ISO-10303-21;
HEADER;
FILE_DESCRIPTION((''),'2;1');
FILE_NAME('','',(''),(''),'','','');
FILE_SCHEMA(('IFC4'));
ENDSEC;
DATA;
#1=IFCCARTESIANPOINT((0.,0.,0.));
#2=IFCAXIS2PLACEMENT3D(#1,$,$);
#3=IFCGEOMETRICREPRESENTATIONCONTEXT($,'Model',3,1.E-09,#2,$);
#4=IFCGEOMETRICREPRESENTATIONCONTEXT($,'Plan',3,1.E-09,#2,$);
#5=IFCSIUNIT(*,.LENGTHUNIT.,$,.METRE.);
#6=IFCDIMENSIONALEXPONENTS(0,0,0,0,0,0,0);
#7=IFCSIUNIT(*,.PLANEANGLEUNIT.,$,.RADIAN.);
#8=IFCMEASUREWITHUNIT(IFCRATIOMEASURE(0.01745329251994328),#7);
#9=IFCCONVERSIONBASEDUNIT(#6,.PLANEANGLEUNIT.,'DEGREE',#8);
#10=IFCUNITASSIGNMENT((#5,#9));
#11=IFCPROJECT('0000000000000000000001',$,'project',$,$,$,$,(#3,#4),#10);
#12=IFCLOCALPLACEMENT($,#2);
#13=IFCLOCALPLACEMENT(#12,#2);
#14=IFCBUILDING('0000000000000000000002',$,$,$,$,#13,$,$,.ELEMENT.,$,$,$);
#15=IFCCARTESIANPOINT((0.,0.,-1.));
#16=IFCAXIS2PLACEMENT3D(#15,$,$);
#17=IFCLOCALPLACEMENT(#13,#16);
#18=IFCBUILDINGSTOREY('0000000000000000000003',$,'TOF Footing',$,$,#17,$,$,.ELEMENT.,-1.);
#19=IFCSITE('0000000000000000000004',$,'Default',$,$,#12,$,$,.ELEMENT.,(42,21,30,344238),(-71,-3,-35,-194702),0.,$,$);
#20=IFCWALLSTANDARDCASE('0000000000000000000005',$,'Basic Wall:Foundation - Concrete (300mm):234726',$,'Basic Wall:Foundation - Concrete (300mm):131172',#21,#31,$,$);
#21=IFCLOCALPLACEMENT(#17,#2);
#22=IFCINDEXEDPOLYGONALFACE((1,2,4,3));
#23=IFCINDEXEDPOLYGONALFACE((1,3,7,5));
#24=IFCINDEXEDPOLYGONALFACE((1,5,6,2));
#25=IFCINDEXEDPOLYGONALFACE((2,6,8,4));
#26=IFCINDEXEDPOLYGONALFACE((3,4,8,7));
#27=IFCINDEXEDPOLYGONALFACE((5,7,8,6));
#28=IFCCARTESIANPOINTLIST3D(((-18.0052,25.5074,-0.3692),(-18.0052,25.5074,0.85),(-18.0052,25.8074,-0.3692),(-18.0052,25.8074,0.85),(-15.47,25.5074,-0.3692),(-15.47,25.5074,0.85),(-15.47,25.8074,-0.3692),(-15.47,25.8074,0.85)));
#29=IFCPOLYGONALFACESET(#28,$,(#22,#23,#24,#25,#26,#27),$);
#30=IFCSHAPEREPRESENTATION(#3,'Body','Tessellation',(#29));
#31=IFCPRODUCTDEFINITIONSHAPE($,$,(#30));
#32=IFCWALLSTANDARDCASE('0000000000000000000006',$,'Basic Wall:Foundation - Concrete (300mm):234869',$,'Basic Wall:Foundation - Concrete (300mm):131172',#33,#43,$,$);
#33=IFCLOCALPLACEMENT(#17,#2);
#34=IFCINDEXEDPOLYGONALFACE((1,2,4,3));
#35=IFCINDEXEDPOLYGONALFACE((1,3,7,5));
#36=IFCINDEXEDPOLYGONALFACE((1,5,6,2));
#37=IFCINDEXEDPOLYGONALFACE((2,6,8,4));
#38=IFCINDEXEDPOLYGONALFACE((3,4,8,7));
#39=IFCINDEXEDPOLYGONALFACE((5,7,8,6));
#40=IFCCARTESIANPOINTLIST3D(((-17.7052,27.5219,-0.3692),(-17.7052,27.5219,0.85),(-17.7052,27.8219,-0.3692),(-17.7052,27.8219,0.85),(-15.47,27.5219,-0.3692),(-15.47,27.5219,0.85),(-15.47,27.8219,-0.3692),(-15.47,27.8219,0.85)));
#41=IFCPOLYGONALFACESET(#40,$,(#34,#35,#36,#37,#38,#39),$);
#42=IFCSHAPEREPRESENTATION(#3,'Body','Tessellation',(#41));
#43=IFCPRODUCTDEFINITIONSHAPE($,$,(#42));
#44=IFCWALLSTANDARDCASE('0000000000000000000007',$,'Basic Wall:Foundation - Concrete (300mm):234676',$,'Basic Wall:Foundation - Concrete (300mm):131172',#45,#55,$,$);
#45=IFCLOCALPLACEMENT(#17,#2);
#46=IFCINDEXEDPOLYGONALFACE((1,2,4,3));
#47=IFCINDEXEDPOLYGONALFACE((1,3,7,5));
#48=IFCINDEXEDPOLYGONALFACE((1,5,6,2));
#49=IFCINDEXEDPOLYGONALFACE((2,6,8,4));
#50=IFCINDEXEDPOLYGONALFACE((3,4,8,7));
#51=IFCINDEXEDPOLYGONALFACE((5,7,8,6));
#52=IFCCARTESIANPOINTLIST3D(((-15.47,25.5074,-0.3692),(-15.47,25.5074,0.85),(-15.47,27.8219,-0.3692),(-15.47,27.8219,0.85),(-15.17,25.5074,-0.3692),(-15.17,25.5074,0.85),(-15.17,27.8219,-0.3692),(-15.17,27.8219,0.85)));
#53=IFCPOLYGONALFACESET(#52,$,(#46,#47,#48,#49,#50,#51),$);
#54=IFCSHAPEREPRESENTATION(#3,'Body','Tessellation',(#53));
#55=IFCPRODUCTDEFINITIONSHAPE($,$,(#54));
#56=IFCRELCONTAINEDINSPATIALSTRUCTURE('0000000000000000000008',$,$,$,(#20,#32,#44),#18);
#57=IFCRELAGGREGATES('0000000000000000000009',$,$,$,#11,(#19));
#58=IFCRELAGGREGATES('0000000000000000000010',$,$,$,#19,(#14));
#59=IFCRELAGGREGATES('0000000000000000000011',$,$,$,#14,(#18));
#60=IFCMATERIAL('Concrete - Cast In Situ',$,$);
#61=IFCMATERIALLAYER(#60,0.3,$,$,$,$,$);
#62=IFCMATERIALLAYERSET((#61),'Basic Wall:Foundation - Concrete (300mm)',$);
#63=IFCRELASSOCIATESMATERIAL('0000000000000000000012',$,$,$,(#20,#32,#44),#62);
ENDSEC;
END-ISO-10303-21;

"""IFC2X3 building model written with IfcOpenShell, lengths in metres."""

from ifc_helpers import new_model, entity, si_unit, converted_unit, frame, frame_2d, origin, place, context, project, spatial, rectangle, extrude, material, layer, layer_set, layer_usage, element, save


model = new_model("IFC2X3")

# Units and contexts
model_context = context("Model", 3, precision=1e-09, world=origin())
plan_context = context("Plan", 3, precision=1e-09, world=origin())
ifc_project = project(units=[si_unit("LENGTHUNIT", "METRE"), converted_unit("PLANEANGLEUNIT", "DEGREE", entity("IfcRatioMeasure", 0.01745329251994328), si_unit("PLANEANGLEUNIT", "RADIAN"), dimensions=[0, 0, 0, 0, 0, 0, 0])], contexts=[model_context, plan_context])

# Site, building, storey
site_placement = place(None, origin())
site = spatial("IfcSite", under=ifc_project, at=site_placement, Name="Default", CompositionType="ELEMENT", RefLatitude=(42, 21, 30, 344238), RefLongitude=(-71, -3, -35, -194702), RefElevation=0.0)
building_placement = place(site_placement, origin())
building = spatial("IfcBuilding", under=site, at=building_placement, CompositionType="ELEMENT")
storey_placement = place(building_placement, frame((0.0, 0.0, -1.0)))
storey = spatial("IfcBuildingStorey", under=building, at=storey_placement, Name="TOF Footing", CompositionType="ELEMENT", Elevation=-1.0)

# Walls
ifc_material_1 = material(Name="Concrete - Cast In Situ")
ifc_layer = layer(ifc_material_1, 0.3)
ifc_layer_set = layer_set([ifc_layer], Name="Basic Wall:Foundation - Concrete (300mm)")
ifc_layer_usage = layer_usage(ifc_layer_set, "AXIS2", "POSITIVE", -0.15)
wall_1_placement = place(storey_placement, frame((-15.47, 25.6574, -0.3692), z_axis=(0.0, 0.0, 1.0), x_axis=(-1.0, 0.0, 0.0)))
element("IfcWallStandardCase", 1, at=wall_1_placement, inside=storey, material=ifc_layer_usage, Name="Basic Wall:Foundation - Concrete (300mm):234726", ObjectType="Basic Wall:Foundation - Concrete (300mm):131172", context=model_context, shape_type="SweptSolid", body=[
    extrude(rectangle(XDim=2.5352, YDim=0.3, at=frame_2d((1.2676, 0.0), x_axis=(-1.0, 0.0))), origin(), (0.0, 0.0, 1.0), 1.2192),
])
wall_2_placement = place(storey_placement, frame((-17.7052, 27.6719, -0.3692)))
element("IfcWallStandardCase", 2, at=wall_2_placement, inside=storey, material=ifc_layer_usage, Name="Basic Wall:Foundation - Concrete (300mm):234869", ObjectType="Basic Wall:Foundation - Concrete (300mm):131172", context=model_context, shape_type="SweptSolid", body=[
    extrude(rectangle(XDim=2.2352, YDim=0.3, at=frame_2d((1.1176, 0.0), x_axis=(-1.0, 0.0))), origin(), (0.0, 0.0, 1.0), 1.2192),
])
wall_3_placement = place(storey_placement, frame((-15.32, 27.8219, -0.3692), z_axis=(0.0, 0.0, 1.0), x_axis=(0.0, -1.0, 0.0)))
element("IfcWallStandardCase", 3, at=wall_3_placement, inside=storey, material=ifc_layer_usage, Name="Basic Wall:Foundation - Concrete (300mm):234676", ObjectType="Basic Wall:Foundation - Concrete (300mm):131172", context=model_context, shape_type="SweptSolid", body=[
    extrude(rectangle(XDim=2.3145, YDim=0.3, at=frame_2d((1.1573, 0.0), x_axis=(-1.0, 0.0))), origin(), (0.0, 0.0, 1.0), 1.2192),
])

save(model, "model.ifc")
